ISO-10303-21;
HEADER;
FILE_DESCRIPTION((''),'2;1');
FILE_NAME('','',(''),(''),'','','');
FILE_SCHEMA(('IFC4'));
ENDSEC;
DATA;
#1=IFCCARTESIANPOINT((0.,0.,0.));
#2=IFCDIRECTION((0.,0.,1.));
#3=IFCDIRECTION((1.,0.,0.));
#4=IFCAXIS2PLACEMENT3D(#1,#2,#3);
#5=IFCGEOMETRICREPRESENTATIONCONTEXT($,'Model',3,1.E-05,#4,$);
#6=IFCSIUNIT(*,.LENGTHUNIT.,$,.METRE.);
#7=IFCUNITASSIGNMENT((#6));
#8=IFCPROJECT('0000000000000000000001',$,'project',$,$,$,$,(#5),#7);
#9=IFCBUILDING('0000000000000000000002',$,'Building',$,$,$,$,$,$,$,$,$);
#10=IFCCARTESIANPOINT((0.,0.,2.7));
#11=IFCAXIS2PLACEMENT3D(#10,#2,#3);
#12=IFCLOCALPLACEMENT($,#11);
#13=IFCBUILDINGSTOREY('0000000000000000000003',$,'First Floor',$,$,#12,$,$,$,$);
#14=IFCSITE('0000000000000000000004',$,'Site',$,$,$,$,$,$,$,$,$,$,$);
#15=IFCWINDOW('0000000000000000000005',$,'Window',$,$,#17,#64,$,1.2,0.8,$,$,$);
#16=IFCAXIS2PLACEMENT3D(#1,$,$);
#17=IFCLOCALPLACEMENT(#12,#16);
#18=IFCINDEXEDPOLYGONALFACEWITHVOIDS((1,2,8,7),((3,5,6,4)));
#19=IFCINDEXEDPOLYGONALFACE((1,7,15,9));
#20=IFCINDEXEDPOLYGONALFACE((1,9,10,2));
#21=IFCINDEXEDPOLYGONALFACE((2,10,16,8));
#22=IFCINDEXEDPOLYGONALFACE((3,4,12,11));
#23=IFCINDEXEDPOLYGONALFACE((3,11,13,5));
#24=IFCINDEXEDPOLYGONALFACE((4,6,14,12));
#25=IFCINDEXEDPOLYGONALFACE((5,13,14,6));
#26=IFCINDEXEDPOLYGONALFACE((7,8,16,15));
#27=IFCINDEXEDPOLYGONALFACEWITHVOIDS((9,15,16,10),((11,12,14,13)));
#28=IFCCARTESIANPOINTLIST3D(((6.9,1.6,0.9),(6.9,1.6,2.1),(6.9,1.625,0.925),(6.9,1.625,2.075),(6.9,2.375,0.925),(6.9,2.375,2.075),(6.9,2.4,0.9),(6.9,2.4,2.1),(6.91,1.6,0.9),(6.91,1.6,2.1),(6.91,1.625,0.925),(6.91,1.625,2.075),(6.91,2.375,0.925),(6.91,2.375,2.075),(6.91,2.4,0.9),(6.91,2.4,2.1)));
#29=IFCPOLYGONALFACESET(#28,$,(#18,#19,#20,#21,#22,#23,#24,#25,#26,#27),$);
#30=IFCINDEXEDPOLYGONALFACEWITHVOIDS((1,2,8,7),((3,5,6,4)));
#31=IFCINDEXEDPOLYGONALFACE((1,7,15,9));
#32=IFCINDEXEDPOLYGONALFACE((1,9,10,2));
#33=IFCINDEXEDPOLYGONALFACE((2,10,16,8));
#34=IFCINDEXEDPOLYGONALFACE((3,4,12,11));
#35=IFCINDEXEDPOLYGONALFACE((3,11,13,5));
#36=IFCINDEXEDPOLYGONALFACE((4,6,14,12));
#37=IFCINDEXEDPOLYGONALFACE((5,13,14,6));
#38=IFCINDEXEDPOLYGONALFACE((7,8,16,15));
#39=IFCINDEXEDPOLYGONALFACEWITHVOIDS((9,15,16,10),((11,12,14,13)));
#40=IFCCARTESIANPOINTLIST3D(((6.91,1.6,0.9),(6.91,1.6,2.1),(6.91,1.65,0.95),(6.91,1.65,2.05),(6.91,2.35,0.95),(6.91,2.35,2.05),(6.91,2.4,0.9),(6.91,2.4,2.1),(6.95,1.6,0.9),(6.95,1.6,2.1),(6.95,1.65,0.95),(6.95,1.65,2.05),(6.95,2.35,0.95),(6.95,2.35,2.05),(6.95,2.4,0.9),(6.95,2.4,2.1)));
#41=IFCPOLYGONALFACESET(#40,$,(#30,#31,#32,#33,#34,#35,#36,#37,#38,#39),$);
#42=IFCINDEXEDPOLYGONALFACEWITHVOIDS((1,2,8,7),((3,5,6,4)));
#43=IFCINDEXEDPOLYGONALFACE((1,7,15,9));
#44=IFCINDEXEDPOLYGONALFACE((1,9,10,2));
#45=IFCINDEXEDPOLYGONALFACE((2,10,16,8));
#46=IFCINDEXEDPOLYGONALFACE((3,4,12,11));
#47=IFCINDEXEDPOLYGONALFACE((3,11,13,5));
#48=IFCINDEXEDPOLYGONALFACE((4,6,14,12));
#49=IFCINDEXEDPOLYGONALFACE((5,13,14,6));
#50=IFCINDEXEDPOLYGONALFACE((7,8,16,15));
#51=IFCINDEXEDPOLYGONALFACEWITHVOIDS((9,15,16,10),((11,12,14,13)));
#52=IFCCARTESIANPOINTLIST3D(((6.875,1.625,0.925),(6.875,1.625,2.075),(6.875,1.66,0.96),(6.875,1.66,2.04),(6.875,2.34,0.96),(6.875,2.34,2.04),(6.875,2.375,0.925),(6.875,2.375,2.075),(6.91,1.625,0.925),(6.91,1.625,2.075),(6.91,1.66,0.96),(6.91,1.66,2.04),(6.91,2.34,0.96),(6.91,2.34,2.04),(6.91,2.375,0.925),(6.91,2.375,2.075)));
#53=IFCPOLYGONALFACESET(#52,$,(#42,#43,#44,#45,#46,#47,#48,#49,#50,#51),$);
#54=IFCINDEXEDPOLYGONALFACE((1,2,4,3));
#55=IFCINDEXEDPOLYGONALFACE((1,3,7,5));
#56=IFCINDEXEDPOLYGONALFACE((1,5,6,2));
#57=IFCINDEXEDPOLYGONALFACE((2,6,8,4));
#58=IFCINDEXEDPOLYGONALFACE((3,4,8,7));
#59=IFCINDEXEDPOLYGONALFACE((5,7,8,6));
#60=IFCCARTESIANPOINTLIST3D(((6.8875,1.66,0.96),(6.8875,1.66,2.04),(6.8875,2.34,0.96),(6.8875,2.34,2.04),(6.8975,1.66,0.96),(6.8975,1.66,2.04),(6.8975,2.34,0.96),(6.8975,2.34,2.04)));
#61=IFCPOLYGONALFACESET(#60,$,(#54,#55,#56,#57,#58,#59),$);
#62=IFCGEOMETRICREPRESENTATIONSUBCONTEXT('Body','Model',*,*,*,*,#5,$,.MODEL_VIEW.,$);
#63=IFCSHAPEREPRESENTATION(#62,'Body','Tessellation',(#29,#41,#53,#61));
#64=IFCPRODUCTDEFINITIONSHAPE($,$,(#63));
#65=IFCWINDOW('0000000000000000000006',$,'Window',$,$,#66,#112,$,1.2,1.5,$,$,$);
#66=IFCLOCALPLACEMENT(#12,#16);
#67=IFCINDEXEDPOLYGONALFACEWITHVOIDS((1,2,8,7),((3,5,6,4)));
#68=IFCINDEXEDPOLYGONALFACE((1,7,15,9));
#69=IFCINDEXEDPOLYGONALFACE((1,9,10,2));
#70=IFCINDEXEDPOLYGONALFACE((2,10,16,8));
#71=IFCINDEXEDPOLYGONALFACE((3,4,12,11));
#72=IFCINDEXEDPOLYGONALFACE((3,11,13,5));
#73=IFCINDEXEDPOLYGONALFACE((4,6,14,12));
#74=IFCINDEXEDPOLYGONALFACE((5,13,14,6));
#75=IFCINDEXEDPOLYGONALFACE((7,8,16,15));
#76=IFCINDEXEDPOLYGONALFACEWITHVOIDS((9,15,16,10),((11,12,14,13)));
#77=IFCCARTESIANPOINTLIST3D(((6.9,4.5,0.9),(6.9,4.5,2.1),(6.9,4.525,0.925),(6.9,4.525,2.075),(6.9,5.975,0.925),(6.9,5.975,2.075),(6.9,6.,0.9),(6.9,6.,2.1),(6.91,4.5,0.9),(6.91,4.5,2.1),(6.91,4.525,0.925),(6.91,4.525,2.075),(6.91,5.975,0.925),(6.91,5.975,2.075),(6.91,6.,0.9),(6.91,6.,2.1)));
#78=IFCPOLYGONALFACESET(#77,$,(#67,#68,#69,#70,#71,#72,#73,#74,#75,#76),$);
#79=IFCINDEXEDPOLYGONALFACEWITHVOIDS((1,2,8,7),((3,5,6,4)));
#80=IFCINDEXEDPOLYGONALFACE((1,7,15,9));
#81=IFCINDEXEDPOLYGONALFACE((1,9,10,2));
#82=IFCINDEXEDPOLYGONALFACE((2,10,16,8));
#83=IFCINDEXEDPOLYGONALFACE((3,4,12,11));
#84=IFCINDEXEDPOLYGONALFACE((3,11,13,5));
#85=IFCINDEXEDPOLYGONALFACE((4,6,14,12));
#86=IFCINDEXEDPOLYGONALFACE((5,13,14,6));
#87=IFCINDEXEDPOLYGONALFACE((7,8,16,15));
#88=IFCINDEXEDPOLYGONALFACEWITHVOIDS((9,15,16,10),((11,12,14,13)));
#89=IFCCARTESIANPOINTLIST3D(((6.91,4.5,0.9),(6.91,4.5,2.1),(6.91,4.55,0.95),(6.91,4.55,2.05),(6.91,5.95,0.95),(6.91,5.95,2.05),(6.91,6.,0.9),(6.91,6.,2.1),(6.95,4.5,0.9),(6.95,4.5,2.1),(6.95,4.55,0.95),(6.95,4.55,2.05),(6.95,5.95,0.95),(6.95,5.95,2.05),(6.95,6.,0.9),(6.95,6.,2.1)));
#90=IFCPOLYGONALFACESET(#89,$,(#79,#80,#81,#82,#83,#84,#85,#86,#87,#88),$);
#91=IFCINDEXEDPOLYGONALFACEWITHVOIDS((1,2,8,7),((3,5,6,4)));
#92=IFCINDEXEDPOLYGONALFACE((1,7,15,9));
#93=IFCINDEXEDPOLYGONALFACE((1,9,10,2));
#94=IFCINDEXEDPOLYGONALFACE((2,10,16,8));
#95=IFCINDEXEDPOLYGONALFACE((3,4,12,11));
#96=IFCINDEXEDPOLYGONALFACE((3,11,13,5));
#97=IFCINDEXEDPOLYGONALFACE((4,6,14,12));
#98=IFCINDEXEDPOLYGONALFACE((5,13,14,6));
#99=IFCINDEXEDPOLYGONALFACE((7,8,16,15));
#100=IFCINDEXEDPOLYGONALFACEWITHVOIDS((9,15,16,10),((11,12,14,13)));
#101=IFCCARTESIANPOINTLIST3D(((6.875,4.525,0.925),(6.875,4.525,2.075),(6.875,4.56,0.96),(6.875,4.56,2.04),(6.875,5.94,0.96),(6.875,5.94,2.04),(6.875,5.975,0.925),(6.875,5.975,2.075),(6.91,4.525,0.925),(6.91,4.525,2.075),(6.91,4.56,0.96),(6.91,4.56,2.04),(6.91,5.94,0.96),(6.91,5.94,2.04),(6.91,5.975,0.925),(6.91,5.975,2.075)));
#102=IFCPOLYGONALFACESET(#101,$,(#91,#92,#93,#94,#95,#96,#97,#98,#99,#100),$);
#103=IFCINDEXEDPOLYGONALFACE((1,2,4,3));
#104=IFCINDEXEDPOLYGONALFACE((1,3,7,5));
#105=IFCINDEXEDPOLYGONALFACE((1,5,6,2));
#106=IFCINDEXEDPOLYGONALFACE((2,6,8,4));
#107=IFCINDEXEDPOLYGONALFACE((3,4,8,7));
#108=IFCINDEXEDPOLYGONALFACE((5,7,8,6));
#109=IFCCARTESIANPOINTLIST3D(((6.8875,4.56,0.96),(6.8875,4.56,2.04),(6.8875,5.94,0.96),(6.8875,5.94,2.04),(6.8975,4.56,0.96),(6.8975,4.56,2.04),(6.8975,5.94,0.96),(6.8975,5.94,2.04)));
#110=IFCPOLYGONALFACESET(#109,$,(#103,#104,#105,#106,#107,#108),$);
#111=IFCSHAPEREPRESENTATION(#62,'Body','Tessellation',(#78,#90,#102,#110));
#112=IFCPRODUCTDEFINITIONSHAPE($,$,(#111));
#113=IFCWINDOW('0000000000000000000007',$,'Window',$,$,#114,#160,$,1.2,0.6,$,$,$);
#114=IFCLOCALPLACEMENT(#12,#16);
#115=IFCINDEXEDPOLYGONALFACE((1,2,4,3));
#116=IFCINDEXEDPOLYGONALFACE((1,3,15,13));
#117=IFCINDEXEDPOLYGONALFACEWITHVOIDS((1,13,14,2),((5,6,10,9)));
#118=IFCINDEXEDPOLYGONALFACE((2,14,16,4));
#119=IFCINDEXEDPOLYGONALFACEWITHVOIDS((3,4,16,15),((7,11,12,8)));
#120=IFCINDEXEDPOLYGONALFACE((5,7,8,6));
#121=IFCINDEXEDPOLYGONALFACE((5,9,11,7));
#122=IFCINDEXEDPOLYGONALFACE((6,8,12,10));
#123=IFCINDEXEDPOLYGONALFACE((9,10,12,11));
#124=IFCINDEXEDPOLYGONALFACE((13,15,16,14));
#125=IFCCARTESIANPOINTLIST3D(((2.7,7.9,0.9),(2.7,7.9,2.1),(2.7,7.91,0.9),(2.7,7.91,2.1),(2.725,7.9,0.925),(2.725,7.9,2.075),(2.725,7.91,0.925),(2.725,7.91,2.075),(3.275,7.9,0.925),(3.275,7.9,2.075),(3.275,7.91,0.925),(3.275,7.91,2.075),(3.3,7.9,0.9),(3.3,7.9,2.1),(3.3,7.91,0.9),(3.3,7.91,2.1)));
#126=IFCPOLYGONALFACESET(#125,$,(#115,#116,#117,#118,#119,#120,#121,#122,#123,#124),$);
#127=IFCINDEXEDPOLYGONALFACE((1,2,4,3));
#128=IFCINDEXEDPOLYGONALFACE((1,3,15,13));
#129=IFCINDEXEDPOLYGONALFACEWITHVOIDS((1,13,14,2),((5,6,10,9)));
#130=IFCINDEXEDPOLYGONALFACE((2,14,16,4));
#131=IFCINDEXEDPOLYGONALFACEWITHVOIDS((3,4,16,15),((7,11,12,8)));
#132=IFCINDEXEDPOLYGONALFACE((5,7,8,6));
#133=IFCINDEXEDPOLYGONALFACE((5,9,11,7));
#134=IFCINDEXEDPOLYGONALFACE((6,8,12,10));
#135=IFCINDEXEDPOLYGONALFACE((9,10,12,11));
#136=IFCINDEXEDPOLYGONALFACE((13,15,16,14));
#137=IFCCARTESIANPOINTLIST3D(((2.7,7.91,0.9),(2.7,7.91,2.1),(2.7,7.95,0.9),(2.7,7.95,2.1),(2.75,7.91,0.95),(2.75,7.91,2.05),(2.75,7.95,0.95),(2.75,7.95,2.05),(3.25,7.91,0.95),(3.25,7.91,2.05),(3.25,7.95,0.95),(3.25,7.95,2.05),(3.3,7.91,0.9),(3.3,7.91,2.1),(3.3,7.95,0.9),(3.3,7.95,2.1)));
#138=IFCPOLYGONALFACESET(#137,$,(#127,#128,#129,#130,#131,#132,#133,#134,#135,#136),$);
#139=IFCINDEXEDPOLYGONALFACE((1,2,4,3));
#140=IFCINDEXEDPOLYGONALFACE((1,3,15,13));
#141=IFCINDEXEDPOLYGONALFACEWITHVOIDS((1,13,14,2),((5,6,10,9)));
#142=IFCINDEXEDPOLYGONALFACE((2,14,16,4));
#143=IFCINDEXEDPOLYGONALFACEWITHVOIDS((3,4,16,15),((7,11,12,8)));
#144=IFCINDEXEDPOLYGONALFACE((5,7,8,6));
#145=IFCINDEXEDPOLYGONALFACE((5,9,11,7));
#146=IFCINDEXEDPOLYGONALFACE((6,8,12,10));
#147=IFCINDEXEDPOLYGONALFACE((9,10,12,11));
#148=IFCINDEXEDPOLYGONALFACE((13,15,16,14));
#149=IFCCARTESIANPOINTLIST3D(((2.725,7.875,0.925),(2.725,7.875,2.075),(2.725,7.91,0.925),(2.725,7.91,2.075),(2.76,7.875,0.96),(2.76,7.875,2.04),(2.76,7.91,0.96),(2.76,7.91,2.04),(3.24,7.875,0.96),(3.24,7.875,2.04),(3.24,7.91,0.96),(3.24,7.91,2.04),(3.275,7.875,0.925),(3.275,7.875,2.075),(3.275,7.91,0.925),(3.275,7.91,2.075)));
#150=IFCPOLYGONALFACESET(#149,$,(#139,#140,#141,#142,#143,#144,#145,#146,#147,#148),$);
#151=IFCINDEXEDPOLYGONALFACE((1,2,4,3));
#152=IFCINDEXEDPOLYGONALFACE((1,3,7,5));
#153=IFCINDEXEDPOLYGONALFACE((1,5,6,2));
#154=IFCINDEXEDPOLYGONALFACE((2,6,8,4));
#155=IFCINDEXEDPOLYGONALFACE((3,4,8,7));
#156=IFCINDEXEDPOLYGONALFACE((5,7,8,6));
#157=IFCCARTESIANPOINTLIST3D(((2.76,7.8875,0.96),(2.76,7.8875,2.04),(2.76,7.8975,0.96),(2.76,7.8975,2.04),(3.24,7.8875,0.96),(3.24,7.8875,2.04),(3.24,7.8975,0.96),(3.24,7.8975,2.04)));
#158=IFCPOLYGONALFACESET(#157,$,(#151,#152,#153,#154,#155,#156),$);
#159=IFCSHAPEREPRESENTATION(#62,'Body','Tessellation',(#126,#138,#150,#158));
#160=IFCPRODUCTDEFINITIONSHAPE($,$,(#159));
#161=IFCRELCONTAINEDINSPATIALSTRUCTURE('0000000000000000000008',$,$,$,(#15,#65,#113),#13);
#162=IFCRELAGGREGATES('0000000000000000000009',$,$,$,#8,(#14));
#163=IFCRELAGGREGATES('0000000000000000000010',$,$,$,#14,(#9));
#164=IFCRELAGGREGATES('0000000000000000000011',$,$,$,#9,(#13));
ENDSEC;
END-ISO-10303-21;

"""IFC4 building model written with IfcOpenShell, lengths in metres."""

from ifc_helpers import new_model, si_unit, frame, origin_with_axes, place, context, subcontext, project, spatial, line, indexed_curve, outline, extrude, element, save


model = new_model("IFC4")

# Units and contexts
model_context = context("Model", 3, precision=1e-05, world=origin_with_axes())
body_context = subcontext(model_context, "Body", "Model", "MODEL_VIEW")
ifc_project = project(units=[si_unit("LENGTHUNIT", "METRE")], contexts=[model_context])

# Site, building, storey
site = spatial("IfcSite", under=ifc_project, Name="Site")
building = spatial("IfcBuilding", under=site, Name="Building")
storey_placement = place(None, frame((0.0, 0.0, 2.7), z_axis=(0.0, 0.0, 1.0), x_axis=(1.0, 0.0, 0.0)))
storey = spatial("IfcBuildingStorey", under=building, at=storey_placement, Name="First Floor")

# Windows
window_1_placement = place(storey_placement, frame((7.0, 1.6, 0.9), z_axis=(0.0, 0.0, 1.0), x_axis=(0.0, 1.0, 0.0)))
element("IfcWindow", 1, at=window_1_placement, inside=storey, Name="Window", OverallHeight=1.2, OverallWidth=0.8, context=body_context, shape_type="SweptSolid", body=[
    extrude(outline(indexed_curve([(0.0, 0.0), (0.8, 0.0), (0.8, 1.2), (0.0, 1.2)], segments=[line(1, 2, 3, 4, 1)]), holes=[indexed_curve([(0.025, 0.025), (0.775, 0.025), (0.775, 1.175), (0.025, 1.175)], segments=[line(1, 2, 3, 4, 1)])]), frame((0.0, 0.09, 0.0), z_axis=(0.0, -1.0, 0.0), x_axis=(1.0, 0.0, 0.0)), (0.0, 0.0, -1.0), 0.01),
    extrude(outline(indexed_curve([(0.0, 0.0), (0.8, 0.0), (0.8, 1.2), (0.0, 1.2)], segments=[line(1, 2, 3, 4, 1)]), holes=[indexed_curve([(0.05, 0.05), (0.75, 0.05), (0.75, 1.15), (0.05, 1.15)], segments=[line(1, 2, 3, 4, 1)])]), frame((0.0, 0.05, 0.0), z_axis=(0.0, -1.0, 0.0), x_axis=(1.0, 0.0, 0.0)), (0.0, 0.0, -1.0), 0.04),
    extrude(outline(indexed_curve([(0.0, 0.0), (0.75, 0.0), (0.75, 1.15), (0.0, 1.15)], segments=[line(1, 2, 3, 4, 1)]), holes=[indexed_curve([(0.035, 0.035), (0.715, 0.035), (0.715, 1.115), (0.035, 1.115)], segments=[line(1, 2, 3, 4, 1)])]), frame((0.025, 0.09, 0.025), z_axis=(0.0, -1.0, 0.0), x_axis=(1.0, 0.0, 0.0)), (0.0, 0.0, -1.0), 0.035),
    extrude(outline(indexed_curve([(0.035, 0.035), (0.715, 0.035), (0.715, 1.115), (0.035, 1.115)], segments=[line(1, 2, 3, 4, 1)])), frame((0.025, 0.1025, 0.025), z_axis=(0.0, -1.0, 0.0), x_axis=(1.0, 0.0, 0.0)), (0.0, 0.0, -1.0), 0.01),
])
window_2_placement = place(storey_placement, frame((7.0, 4.5, 0.9), z_axis=(0.0, 0.0, 1.0), x_axis=(0.0, 1.0, 0.0)))
element("IfcWindow", 2, at=window_2_placement, inside=storey, Name="Window", OverallHeight=1.2, OverallWidth=1.5, context=body_context, shape_type="SweptSolid", body=[
    extrude(outline(indexed_curve([(0.0, 0.0), (1.5, 0.0), (1.5, 1.2), (0.0, 1.2)], segments=[line(1, 2, 3, 4, 1)]), holes=[indexed_curve([(0.025, 0.025), (1.475, 0.025), (1.475, 1.175), (0.025, 1.175)], segments=[line(1, 2, 3, 4, 1)])]), frame((0.0, 0.09, 0.0), z_axis=(0.0, -1.0, 0.0), x_axis=(1.0, 0.0, 0.0)), (0.0, 0.0, -1.0), 0.01),
    extrude(outline(indexed_curve([(0.0, 0.0), (1.5, 0.0), (1.5, 1.2), (0.0, 1.2)], segments=[line(1, 2, 3, 4, 1)]), holes=[indexed_curve([(0.05, 0.05), (1.45, 0.05), (1.45, 1.15), (0.05, 1.15)], segments=[line(1, 2, 3, 4, 1)])]), frame((0.0, 0.05, 0.0), z_axis=(0.0, -1.0, 0.0), x_axis=(1.0, 0.0, 0.0)), (0.0, 0.0, -1.0), 0.04),
    extrude(outline(indexed_curve([(0.0, 0.0), (1.45, 0.0), (1.45, 1.15), (0.0, 1.15)], segments=[line(1, 2, 3, 4, 1)]), holes=[indexed_curve([(0.035, 0.035), (1.415, 0.035), (1.415, 1.115), (0.035, 1.115)], segments=[line(1, 2, 3, 4, 1)])]), frame((0.025, 0.09, 0.025), z_axis=(0.0, -1.0, 0.0), x_axis=(1.0, 0.0, 0.0)), (0.0, 0.0, -1.0), 0.035),
    extrude(outline(indexed_curve([(0.035, 0.035), (1.415, 0.035), (1.415, 1.115), (0.035, 1.115)], segments=[line(1, 2, 3, 4, 1)])), frame((0.025, 0.1025, 0.025), z_axis=(0.0, -1.0, 0.0), x_axis=(1.0, 0.0, 0.0)), (0.0, 0.0, -1.0), 0.01),
])
window_3_placement = place(storey_placement, frame((3.3, 8.0, 0.9), z_axis=(0.0, 0.0, 1.0), x_axis=(-1.0, 0.0, 0.0)))
element("IfcWindow", 3, at=window_3_placement, inside=storey, Name="Window", OverallHeight=1.2, OverallWidth=0.6, context=body_context, shape_type="SweptSolid", body=[
    extrude(outline(indexed_curve([(0.0, 0.0), (0.6, 0.0), (0.6, 1.2), (0.0, 1.2)], segments=[line(1, 2, 3, 4, 1)]), holes=[indexed_curve([(0.025, 0.025), (0.575, 0.025), (0.575, 1.175), (0.025, 1.175)], segments=[line(1, 2, 3, 4, 1)])]), frame((0.0, 0.09, 0.0), z_axis=(0.0, -1.0, 0.0), x_axis=(1.0, 0.0, 0.0)), (0.0, 0.0, -1.0), 0.01),
    extrude(outline(indexed_curve([(0.0, 0.0), (0.6, 0.0), (0.6, 1.2), (0.0, 1.2)], segments=[line(1, 2, 3, 4, 1)]), holes=[indexed_curve([(0.05, 0.05), (0.55, 0.05), (0.55, 1.15), (0.05, 1.15)], segments=[line(1, 2, 3, 4, 1)])]), frame((0.0, 0.05, 0.0), z_axis=(0.0, -1.0, 0.0), x_axis=(1.0, 0.0, 0.0)), (0.0, 0.0, -1.0), 0.04),
    extrude(outline(indexed_curve([(0.0, 0.0), (0.55, 0.0), (0.55, 1.15), (0.0, 1.15)], segments=[line(1, 2, 3, 4, 1)]), holes=[indexed_curve([(0.035, 0.035), (0.515, 0.035), (0.515, 1.115), (0.035, 1.115)], segments=[line(1, 2, 3, 4, 1)])]), frame((0.025, 0.09, 0.025), z_axis=(0.0, -1.0, 0.0), x_axis=(1.0, 0.0, 0.0)), (0.0, 0.0, -1.0), 0.035),
    extrude(outline(indexed_curve([(0.035, 0.035), (0.515, 0.035), (0.515, 1.115), (0.035, 1.115)], segments=[line(1, 2, 3, 4, 1)])), frame((0.025, 0.1025, 0.025), z_axis=(0.0, -1.0, 0.0), x_axis=(1.0, 0.0, 0.0)), (0.0, 0.0, -1.0), 0.01),
])

save(model, "model.ifc")
